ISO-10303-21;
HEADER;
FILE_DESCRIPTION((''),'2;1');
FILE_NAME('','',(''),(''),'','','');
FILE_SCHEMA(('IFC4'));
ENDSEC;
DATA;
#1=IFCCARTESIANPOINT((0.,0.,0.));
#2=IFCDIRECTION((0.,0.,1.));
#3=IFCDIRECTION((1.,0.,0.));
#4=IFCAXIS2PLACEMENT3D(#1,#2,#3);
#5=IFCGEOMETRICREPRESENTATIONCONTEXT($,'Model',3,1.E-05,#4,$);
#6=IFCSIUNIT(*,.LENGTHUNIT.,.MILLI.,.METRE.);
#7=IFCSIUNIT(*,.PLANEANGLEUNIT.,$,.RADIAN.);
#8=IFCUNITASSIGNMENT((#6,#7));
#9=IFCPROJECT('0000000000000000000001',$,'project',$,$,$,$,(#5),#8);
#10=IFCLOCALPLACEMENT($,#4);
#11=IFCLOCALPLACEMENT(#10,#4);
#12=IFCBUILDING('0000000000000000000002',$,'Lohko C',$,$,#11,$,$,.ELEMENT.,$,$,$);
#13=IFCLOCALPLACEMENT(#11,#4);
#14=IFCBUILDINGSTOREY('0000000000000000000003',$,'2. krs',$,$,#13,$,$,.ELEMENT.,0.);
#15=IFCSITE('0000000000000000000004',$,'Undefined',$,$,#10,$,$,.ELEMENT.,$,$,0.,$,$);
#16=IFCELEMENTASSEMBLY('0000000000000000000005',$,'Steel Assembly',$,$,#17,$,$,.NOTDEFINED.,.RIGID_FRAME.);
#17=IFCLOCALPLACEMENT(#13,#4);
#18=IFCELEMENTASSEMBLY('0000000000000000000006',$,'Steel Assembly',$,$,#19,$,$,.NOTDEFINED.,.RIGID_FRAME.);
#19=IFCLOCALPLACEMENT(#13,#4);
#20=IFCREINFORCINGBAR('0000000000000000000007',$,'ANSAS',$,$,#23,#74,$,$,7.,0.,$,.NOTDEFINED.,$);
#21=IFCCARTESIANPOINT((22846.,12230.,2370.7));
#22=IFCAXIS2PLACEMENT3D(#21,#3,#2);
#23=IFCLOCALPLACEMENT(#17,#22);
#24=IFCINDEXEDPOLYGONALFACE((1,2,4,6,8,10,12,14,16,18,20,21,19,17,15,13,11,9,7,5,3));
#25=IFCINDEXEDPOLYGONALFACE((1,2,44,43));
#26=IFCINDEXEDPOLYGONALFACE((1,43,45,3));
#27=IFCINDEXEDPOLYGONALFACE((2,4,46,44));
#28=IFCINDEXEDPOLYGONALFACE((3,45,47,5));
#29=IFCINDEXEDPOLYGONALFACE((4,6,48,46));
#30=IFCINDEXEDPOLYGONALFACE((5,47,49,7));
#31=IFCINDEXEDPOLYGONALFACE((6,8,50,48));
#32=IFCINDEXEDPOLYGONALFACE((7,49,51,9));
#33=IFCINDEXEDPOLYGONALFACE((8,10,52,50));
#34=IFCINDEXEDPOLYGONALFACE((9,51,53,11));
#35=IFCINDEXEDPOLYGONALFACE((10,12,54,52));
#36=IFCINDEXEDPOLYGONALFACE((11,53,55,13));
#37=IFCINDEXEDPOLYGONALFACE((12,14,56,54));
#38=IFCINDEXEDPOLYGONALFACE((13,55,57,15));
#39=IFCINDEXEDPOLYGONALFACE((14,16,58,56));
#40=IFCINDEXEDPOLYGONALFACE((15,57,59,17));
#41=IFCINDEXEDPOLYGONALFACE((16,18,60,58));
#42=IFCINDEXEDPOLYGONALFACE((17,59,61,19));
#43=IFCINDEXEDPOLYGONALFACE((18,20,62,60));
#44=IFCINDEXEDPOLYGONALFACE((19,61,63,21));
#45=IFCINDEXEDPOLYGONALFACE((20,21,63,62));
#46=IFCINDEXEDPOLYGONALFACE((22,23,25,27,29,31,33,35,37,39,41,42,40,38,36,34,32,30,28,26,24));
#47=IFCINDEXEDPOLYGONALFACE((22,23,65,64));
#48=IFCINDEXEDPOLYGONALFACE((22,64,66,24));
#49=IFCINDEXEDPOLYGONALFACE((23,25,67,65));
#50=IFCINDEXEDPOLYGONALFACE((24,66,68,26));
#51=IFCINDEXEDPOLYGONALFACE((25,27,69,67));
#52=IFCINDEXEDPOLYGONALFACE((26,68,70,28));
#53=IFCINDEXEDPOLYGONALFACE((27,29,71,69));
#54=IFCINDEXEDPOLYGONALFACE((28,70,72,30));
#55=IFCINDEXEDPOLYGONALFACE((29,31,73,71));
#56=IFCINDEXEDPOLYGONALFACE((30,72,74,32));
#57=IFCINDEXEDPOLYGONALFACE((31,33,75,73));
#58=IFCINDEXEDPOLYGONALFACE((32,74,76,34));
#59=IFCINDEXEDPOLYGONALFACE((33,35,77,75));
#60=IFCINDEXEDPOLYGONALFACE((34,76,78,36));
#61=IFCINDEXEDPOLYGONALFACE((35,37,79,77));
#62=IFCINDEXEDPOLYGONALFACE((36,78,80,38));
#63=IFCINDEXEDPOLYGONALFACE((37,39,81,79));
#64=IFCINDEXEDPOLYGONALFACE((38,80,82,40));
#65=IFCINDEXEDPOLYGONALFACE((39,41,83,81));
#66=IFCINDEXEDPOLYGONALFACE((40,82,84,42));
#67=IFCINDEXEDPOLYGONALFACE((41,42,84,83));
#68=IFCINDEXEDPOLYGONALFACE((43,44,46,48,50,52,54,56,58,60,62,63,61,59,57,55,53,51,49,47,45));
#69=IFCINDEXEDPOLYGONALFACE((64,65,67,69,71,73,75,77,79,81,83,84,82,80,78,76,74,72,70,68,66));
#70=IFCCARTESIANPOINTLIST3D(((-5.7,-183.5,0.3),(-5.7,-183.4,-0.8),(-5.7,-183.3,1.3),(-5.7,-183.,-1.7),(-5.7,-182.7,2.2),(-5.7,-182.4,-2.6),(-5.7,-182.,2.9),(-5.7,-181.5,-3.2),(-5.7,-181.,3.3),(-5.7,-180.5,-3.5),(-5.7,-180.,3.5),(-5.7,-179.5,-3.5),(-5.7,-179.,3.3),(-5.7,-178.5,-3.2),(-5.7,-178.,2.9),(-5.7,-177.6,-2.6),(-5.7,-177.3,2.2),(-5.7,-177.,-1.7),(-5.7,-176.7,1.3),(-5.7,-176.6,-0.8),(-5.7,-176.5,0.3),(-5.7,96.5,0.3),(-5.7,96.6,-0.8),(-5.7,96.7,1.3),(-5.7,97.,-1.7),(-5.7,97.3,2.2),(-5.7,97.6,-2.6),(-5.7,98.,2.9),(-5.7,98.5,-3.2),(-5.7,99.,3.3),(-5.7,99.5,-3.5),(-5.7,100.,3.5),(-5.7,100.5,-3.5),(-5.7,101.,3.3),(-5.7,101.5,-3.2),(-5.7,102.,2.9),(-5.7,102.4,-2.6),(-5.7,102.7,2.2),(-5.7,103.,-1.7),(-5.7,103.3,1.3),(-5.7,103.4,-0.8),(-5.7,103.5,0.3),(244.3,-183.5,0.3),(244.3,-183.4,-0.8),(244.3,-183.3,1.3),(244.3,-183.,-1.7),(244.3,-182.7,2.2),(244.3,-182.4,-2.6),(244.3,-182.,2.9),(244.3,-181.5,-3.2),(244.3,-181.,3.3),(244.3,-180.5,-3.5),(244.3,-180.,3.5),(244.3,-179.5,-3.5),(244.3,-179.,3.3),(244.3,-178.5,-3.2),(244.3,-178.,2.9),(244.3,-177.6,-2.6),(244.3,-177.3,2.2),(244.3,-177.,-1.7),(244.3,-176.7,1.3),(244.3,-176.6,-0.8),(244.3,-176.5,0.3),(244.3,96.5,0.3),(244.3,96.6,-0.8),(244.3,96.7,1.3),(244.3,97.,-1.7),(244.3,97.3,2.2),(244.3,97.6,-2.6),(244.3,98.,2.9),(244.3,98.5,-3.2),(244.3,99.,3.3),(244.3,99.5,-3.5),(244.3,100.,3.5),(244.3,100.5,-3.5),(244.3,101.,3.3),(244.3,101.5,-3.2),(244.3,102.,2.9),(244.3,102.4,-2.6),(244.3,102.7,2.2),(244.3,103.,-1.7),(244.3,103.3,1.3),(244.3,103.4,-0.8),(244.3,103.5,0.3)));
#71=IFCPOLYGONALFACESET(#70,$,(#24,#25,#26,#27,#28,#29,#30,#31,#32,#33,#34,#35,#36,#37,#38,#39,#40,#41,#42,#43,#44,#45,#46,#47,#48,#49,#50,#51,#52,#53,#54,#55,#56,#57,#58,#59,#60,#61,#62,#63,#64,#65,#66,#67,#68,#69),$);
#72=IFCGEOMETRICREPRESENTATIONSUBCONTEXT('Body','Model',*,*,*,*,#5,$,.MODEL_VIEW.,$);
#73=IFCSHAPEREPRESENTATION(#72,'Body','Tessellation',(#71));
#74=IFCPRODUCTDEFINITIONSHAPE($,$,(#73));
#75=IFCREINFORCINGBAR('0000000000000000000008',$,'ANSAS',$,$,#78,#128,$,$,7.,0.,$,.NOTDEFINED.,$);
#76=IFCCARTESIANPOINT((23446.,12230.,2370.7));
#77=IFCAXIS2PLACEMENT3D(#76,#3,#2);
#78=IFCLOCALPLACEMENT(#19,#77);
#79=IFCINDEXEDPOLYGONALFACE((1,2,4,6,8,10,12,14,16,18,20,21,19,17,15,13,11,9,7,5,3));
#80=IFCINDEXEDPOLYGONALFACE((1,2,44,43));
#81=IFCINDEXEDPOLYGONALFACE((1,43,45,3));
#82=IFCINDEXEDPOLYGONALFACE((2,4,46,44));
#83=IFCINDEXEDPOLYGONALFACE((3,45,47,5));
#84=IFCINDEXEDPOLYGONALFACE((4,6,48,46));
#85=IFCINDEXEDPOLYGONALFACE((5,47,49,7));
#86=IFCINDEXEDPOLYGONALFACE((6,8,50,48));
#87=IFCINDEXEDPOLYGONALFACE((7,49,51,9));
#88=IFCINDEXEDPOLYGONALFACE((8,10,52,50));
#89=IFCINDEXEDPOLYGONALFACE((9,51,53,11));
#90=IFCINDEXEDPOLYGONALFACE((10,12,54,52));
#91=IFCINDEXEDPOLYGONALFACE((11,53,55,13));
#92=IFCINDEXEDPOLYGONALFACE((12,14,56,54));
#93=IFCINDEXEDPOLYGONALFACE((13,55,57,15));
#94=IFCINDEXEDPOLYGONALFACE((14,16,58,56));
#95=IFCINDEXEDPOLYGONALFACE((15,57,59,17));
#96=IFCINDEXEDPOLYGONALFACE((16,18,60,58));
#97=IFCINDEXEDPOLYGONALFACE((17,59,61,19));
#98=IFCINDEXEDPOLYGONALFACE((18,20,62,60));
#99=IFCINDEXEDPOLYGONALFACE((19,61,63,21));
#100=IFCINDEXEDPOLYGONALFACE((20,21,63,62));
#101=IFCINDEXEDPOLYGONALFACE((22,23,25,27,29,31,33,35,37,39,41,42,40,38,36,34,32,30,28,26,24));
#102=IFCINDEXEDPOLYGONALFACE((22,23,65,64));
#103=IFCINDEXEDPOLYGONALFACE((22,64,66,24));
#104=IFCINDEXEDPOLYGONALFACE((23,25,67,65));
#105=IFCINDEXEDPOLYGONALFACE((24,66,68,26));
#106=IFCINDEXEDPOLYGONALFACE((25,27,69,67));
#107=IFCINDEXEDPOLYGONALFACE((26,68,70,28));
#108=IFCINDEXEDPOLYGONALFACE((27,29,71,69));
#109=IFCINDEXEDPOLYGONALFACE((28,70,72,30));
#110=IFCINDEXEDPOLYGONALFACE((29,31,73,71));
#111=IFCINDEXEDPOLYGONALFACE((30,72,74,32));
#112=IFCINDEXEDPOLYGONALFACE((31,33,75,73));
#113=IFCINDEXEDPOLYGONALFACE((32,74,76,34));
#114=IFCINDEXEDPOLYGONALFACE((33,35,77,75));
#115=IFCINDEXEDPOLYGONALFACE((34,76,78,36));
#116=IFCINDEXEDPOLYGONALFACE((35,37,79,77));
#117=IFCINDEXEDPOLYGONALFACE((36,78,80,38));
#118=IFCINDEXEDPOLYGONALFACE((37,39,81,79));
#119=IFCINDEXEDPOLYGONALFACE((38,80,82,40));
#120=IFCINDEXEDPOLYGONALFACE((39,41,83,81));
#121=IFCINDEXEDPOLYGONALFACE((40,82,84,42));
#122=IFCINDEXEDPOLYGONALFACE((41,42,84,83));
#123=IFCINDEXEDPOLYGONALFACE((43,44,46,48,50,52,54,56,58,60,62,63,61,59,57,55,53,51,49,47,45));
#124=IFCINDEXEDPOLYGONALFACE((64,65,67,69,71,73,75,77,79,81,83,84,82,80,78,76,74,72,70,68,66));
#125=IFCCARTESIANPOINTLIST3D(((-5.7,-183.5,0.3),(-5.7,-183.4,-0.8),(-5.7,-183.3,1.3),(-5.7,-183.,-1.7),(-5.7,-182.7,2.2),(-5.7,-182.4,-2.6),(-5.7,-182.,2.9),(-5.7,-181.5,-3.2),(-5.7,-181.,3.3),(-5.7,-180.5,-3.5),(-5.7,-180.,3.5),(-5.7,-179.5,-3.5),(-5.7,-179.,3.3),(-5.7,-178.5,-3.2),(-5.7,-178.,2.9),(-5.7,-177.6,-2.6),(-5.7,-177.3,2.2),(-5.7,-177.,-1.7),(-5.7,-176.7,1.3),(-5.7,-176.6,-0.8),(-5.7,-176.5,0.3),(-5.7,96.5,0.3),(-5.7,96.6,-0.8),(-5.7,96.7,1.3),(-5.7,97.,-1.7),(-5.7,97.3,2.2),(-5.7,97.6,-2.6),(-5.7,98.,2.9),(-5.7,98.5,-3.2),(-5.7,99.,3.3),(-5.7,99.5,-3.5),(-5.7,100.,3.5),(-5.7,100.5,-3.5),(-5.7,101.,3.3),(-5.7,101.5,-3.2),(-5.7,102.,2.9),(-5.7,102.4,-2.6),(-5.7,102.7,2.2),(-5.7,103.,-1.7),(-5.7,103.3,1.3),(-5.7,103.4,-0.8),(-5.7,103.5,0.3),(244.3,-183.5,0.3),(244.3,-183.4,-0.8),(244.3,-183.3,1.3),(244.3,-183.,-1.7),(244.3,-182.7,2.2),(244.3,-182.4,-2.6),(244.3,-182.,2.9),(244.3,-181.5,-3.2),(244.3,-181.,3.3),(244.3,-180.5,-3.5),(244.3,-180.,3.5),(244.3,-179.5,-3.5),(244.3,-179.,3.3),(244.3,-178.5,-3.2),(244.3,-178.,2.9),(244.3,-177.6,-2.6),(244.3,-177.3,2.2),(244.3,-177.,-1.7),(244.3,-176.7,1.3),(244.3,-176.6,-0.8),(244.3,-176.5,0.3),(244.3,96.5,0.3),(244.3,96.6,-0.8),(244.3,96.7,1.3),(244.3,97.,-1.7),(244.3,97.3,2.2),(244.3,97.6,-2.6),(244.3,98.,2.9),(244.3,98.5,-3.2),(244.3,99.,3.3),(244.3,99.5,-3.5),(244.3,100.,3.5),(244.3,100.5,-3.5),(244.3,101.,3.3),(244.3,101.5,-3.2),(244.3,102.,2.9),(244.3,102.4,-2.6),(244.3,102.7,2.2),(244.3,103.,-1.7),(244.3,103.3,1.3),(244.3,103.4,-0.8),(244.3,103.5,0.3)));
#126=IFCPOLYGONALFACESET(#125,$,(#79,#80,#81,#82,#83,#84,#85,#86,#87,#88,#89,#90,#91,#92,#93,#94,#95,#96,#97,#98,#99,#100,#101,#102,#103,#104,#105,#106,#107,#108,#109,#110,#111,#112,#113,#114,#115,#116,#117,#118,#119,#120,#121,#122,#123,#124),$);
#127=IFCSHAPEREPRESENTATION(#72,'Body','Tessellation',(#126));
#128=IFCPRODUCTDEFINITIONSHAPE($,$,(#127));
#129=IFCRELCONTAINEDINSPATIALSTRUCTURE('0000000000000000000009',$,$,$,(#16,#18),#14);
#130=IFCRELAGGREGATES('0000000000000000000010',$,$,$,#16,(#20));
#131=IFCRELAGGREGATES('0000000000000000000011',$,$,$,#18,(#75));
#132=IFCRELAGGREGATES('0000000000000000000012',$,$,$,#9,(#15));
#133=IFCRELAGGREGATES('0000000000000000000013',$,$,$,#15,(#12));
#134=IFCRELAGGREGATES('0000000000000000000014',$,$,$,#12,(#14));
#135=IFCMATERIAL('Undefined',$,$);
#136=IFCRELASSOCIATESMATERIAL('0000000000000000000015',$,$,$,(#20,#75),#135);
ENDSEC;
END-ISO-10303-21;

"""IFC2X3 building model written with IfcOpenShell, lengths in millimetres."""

from ifc_helpers import new_model, entity, si_unit, frame, origin_with_axes, place, context, subcontext, project, spatial, source, transform, mapped, material, element, aggregate, save


model = new_model("IFC2X3")

# Units and contexts
model_context = context("Model", 3, precision=1e-05, world=origin_with_axes())
body_context = subcontext(model_context, "Body", "Model", "MODEL_VIEW")
ifc_project = project(units=[si_unit("LENGTHUNIT", "METRE", prefix="MILLI"), si_unit("PLANEANGLEUNIT", "RADIAN")], contexts=[model_context])

# Site, building, storey
site_placement = place(None, origin_with_axes())
site = spatial("IfcSite", under=ifc_project, at=site_placement, Name="Undefined", CompositionType="ELEMENT", RefElevation=0.0)
building_placement = place(site_placement, origin_with_axes())
building = spatial("IfcBuilding", under=site, at=building_placement, Name="Lohko C", CompositionType="ELEMENT")
storey_placement = place(building_placement, origin_with_axes())
storey = spatial("IfcBuildingStorey", under=building, at=storey_placement, Name="2. krs", CompositionType="ELEMENT", Elevation=0.0)

# Element assemblies
assembly_1_placement = place(storey_placement, origin_with_axes())
assembly_1 = element("IfcElementAssembly", 1, at=assembly_1_placement, inside=storey, Name="Steel Assembly", AssemblyPlace="NOTDEFINED", PredefinedType="RIGID_FRAME")
assembly_2_placement = place(storey_placement, origin_with_axes())
assembly_2 = element("IfcElementAssembly", 2, at=assembly_2_placement, inside=storey, Name="Steel Assembly", AssemblyPlace="NOTDEFINED", PredefinedType="RIGID_FRAME")

# Reinforcing bars
ifc_material_1 = material(Name="Undefined")
shared_shape_1 = source(origin_with_axes(), body_context, "Body", "AdvancedSweptSolid", [
    entity("IfcSweptDiskSolid", entity("IfcTrimmedCurve", entity("IfcLine", entity("IfcCartesianPoint", [0.0, 0.0, 0.0]), entity("IfcVector", entity("IfcDirection", [1.0, 0.0, 0.0]), 1.0)), [entity("IfcParameterValue", 0.0)], [entity("IfcParameterValue", 250.0)], True, "PARAMETER"), 3.5, None, 0.0, 250.0),
])
shared_shape_2 = source(origin_with_axes(), body_context, "Body", "AdvancedSweptSolid", [
    entity("IfcSweptDiskSolid", entity("IfcTrimmedCurve", entity("IfcLine", entity("IfcCartesianPoint", [0.0, 0.0, 0.0]), entity("IfcVector", entity("IfcDirection", [1.0, 0.0, 0.0]), 1.0)), [entity("IfcParameterValue", 0.0)], [entity("IfcParameterValue", 250.0)], True, "PARAMETER"), 3.5, None, 0.0, 250.0),
])
reinforcing_bar_1_placement = place(assembly_1_placement, frame((22846.0, 12230.0, 2370.7), z_axis=(1.0, 0.0, 0.0), x_axis=(0.0, 0.0, 1.0)))
reinforcing_bar_1 = element("IfcReinforcingBar", 3, at=reinforcing_bar_1_placement, material=ifc_material_1, Name="ANSAS", BarRole="NOTDEFINED", CrossSectionArea=0.0, NominalDiameter=7.0, context=body_context, shape_type="MappedRepresentation", body=[
    mapped(shared_shape_1, transform((-5.7, -180.0, 0.0))),
    mapped(shared_shape_2, transform((-5.7, 100.0, 0.0))),
])
aggregate(assembly_1, [reinforcing_bar_1])
shared_shape_3 = source(origin_with_axes(), body_context, "Body", "AdvancedSweptSolid", [
    entity("IfcSweptDiskSolid", entity("IfcTrimmedCurve", entity("IfcLine", entity("IfcCartesianPoint", [0.0, 0.0, 0.0]), entity("IfcVector", entity("IfcDirection", [1.0, 0.0, 0.0]), 1.0)), [entity("IfcParameterValue", 0.0)], [entity("IfcParameterValue", 250.0)], True, "PARAMETER"), 3.5, None, 0.0, 250.0),
])
shared_shape_4 = source(origin_with_axes(), body_context, "Body", "AdvancedSweptSolid", [
    entity("IfcSweptDiskSolid", entity("IfcTrimmedCurve", entity("IfcLine", entity("IfcCartesianPoint", [0.0, 0.0, 0.0]), entity("IfcVector", entity("IfcDirection", [1.0, 0.0, 0.0]), 1.0)), [entity("IfcParameterValue", 0.0)], [entity("IfcParameterValue", 250.0)], True, "PARAMETER"), 3.5, None, 0.0, 250.0),
])
reinforcing_bar_2_placement = place(assembly_2_placement, frame((23446.0, 12230.0, 2370.7), z_axis=(1.0, 0.0, 0.0), x_axis=(0.0, 0.0, 1.0)))
reinforcing_bar_2 = element("IfcReinforcingBar", 4, at=reinforcing_bar_2_placement, material=ifc_material_1, Name="ANSAS", BarRole="NOTDEFINED", CrossSectionArea=0.0, NominalDiameter=7.0, context=body_context, shape_type="MappedRepresentation", body=[
    mapped(shared_shape_3, transform((-5.7, -180.0, 0.0))),
    mapped(shared_shape_4, transform((-5.7, 100.0, 0.0))),
])
aggregate(assembly_2, [reinforcing_bar_2])

save(model, "model.ifc")
